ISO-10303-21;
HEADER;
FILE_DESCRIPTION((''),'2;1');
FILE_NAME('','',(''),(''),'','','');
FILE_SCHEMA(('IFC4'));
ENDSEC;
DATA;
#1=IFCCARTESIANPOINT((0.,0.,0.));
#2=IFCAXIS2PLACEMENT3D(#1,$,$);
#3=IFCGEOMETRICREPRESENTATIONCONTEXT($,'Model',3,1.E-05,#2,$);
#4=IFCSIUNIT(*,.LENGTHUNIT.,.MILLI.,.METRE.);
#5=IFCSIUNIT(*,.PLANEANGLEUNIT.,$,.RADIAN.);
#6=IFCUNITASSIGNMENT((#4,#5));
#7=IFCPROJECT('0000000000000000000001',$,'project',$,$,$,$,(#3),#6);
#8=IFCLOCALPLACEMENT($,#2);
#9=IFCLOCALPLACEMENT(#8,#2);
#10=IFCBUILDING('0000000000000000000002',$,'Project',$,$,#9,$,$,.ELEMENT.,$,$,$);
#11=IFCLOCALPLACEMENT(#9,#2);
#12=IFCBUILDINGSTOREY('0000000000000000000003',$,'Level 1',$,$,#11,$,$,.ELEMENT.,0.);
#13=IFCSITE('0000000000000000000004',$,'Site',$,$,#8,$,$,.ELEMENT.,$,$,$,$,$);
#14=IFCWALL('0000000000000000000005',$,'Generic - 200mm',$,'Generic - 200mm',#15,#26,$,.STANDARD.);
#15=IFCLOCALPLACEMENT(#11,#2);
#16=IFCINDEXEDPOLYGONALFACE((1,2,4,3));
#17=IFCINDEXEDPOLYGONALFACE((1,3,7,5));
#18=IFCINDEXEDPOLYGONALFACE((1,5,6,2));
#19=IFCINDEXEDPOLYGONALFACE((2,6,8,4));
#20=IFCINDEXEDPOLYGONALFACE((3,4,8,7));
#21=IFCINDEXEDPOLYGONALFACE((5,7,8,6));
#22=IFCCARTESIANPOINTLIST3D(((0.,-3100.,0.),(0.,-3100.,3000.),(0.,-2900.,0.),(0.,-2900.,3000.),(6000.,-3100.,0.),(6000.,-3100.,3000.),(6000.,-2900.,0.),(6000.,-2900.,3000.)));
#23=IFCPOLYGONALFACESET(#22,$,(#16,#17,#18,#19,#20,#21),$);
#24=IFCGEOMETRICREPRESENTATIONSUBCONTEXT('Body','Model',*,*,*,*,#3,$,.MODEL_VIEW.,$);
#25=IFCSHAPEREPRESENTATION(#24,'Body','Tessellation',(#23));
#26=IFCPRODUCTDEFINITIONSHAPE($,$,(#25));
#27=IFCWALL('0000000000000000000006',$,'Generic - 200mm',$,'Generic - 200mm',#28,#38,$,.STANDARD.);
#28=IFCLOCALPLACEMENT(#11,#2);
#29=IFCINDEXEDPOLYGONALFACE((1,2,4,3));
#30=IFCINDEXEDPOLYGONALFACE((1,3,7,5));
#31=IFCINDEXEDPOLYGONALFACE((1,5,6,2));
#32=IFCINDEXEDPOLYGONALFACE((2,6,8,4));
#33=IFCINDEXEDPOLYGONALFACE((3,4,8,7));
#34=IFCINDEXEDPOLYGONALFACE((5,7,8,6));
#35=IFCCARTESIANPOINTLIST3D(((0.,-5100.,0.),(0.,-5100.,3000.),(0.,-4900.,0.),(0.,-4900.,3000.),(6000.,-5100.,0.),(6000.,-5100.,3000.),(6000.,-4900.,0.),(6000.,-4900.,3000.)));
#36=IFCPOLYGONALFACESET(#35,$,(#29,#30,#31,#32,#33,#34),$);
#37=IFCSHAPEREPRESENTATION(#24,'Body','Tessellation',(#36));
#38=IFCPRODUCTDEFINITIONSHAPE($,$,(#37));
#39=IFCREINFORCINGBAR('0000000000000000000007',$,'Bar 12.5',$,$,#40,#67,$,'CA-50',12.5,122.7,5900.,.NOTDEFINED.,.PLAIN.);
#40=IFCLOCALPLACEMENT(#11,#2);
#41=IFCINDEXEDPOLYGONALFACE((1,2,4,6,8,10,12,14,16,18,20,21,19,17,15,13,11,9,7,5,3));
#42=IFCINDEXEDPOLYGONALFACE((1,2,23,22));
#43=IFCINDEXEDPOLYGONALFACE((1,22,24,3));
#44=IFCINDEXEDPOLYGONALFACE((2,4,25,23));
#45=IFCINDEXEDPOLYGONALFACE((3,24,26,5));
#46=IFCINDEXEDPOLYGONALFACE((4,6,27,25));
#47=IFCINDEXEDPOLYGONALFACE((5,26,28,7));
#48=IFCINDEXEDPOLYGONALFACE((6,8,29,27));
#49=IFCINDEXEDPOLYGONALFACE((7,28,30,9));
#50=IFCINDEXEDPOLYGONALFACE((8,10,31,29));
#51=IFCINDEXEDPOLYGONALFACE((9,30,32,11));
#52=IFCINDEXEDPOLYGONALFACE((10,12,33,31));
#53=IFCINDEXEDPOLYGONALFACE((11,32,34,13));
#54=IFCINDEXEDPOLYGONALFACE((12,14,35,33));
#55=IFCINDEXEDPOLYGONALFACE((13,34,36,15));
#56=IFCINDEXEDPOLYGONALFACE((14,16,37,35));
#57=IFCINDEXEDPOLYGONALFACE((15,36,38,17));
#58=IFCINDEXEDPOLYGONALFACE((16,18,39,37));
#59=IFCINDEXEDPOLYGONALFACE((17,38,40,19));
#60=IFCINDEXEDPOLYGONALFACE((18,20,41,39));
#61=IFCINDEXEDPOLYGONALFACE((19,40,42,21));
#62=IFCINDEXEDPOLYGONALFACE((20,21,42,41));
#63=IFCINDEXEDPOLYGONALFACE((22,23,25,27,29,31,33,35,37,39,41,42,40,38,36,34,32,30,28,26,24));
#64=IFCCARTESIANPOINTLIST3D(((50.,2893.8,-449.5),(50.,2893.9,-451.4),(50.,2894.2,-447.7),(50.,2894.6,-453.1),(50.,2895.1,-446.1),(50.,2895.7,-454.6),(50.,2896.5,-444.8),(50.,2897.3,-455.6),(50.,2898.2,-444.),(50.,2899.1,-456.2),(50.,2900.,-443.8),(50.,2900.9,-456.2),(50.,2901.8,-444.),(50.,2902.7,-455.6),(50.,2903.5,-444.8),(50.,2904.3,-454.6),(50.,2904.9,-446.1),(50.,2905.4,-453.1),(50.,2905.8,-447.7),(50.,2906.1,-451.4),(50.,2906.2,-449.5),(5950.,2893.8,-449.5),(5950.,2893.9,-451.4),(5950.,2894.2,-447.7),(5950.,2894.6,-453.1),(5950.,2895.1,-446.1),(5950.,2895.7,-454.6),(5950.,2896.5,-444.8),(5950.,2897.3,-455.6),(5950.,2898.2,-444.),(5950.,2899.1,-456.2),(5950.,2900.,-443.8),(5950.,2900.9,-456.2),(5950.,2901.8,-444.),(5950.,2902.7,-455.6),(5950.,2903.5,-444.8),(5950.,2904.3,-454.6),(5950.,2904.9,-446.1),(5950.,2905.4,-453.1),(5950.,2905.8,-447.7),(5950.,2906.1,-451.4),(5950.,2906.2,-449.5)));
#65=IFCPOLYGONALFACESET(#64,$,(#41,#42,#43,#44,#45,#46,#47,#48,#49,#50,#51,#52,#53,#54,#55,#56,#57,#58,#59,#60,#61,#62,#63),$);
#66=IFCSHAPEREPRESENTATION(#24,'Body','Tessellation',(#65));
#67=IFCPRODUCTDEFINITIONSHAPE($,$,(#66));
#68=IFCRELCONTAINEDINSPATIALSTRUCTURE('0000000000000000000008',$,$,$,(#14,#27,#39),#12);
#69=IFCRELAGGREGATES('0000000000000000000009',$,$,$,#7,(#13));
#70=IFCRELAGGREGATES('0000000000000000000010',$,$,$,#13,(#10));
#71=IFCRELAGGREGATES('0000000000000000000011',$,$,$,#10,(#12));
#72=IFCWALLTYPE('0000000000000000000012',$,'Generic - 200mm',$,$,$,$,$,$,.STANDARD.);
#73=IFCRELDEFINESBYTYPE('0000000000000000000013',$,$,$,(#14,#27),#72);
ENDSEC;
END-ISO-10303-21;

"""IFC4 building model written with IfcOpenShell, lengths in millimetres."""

from ifc_helpers import new_model, entity, si_unit, frame, origin, place, context, subcontext, project, spatial, polyline, outline, extrude, type_object, element, save


model = new_model("IFC4")

# Units and contexts
model_context = context("Model", 3, precision=1e-05, world=origin())
body_context = subcontext(model_context, "Body", "Model", "MODEL_VIEW")
ifc_project = project(units=[si_unit("LENGTHUNIT", "METRE", prefix="MILLI"), si_unit("PLANEANGLEUNIT", "RADIAN")], contexts=[model_context])

# Site, building, storey
site_placement = place(None, origin())
site = spatial("IfcSite", under=ifc_project, at=site_placement, Name="Site", CompositionType="ELEMENT")
building_placement = place(site_placement, origin())
building = spatial("IfcBuilding", under=site, at=building_placement, Name="Project", CompositionType="ELEMENT")
storey_placement = place(building_placement, origin())
storey = spatial("IfcBuildingStorey", under=building, at=storey_placement, Name="Level 1", CompositionType="ELEMENT", Elevation=0.0)

# Walls
wall_type = type_object("IfcWallType", Name="Generic - 200mm", PredefinedType="STANDARD")
for number, where, z_axis, x_axis, name in (
    (1, (0.0, -3000.0, 0.0), (0.0, 0.0, 1.0), (1.0, 0.0, 0.0), "Generic - 200mm"),
    (2, (0.0, -5000.0, 0.0), (0.0, 0.0, 1.0), (1.0, 0.0, 0.0), "Generic - 200mm"),
):
    element("IfcWall", number, at=place(storey_placement, frame(where, z_axis=z_axis, x_axis=x_axis)), inside=storey, type_object=wall_type, Name=name, ObjectType="Generic - 200mm", PredefinedType="STANDARD", context=body_context, shape_type="SweptSolid", body=[
        extrude(outline(polyline([(0.0, -100.0), (0.0, 100.0), (6000.0, 100.0), (6000.0, -100.0), (0.0, -100.0)])), origin(), (0.0, 0.0, 1.0), 3000.0),
    ])

# Reinforcing bar
reinforcing_bar_1_placement = place(storey_placement, origin())
element("IfcReinforcingBar", 3, at=reinforcing_bar_1_placement, inside=storey, Name="Bar 12.5", SteelGrade="CA-50", BarLength=5900.0, BarSurface="PLAIN", CrossSectionArea=122.7, NominalDiameter=12.5, PredefinedType="NOTDEFINED", context=body_context, shape_type="AdvancedSweptSolid", body=[
    entity("IfcSweptDiskSolid", entity("IfcPolyline", [entity("IfcCartesianPoint", [50.0, 2900.0, -450.0]), entity("IfcCartesianPoint", [5950.0, 2900.0, -450.0])]), 6.2),
])

save(model, "model.ifc")
